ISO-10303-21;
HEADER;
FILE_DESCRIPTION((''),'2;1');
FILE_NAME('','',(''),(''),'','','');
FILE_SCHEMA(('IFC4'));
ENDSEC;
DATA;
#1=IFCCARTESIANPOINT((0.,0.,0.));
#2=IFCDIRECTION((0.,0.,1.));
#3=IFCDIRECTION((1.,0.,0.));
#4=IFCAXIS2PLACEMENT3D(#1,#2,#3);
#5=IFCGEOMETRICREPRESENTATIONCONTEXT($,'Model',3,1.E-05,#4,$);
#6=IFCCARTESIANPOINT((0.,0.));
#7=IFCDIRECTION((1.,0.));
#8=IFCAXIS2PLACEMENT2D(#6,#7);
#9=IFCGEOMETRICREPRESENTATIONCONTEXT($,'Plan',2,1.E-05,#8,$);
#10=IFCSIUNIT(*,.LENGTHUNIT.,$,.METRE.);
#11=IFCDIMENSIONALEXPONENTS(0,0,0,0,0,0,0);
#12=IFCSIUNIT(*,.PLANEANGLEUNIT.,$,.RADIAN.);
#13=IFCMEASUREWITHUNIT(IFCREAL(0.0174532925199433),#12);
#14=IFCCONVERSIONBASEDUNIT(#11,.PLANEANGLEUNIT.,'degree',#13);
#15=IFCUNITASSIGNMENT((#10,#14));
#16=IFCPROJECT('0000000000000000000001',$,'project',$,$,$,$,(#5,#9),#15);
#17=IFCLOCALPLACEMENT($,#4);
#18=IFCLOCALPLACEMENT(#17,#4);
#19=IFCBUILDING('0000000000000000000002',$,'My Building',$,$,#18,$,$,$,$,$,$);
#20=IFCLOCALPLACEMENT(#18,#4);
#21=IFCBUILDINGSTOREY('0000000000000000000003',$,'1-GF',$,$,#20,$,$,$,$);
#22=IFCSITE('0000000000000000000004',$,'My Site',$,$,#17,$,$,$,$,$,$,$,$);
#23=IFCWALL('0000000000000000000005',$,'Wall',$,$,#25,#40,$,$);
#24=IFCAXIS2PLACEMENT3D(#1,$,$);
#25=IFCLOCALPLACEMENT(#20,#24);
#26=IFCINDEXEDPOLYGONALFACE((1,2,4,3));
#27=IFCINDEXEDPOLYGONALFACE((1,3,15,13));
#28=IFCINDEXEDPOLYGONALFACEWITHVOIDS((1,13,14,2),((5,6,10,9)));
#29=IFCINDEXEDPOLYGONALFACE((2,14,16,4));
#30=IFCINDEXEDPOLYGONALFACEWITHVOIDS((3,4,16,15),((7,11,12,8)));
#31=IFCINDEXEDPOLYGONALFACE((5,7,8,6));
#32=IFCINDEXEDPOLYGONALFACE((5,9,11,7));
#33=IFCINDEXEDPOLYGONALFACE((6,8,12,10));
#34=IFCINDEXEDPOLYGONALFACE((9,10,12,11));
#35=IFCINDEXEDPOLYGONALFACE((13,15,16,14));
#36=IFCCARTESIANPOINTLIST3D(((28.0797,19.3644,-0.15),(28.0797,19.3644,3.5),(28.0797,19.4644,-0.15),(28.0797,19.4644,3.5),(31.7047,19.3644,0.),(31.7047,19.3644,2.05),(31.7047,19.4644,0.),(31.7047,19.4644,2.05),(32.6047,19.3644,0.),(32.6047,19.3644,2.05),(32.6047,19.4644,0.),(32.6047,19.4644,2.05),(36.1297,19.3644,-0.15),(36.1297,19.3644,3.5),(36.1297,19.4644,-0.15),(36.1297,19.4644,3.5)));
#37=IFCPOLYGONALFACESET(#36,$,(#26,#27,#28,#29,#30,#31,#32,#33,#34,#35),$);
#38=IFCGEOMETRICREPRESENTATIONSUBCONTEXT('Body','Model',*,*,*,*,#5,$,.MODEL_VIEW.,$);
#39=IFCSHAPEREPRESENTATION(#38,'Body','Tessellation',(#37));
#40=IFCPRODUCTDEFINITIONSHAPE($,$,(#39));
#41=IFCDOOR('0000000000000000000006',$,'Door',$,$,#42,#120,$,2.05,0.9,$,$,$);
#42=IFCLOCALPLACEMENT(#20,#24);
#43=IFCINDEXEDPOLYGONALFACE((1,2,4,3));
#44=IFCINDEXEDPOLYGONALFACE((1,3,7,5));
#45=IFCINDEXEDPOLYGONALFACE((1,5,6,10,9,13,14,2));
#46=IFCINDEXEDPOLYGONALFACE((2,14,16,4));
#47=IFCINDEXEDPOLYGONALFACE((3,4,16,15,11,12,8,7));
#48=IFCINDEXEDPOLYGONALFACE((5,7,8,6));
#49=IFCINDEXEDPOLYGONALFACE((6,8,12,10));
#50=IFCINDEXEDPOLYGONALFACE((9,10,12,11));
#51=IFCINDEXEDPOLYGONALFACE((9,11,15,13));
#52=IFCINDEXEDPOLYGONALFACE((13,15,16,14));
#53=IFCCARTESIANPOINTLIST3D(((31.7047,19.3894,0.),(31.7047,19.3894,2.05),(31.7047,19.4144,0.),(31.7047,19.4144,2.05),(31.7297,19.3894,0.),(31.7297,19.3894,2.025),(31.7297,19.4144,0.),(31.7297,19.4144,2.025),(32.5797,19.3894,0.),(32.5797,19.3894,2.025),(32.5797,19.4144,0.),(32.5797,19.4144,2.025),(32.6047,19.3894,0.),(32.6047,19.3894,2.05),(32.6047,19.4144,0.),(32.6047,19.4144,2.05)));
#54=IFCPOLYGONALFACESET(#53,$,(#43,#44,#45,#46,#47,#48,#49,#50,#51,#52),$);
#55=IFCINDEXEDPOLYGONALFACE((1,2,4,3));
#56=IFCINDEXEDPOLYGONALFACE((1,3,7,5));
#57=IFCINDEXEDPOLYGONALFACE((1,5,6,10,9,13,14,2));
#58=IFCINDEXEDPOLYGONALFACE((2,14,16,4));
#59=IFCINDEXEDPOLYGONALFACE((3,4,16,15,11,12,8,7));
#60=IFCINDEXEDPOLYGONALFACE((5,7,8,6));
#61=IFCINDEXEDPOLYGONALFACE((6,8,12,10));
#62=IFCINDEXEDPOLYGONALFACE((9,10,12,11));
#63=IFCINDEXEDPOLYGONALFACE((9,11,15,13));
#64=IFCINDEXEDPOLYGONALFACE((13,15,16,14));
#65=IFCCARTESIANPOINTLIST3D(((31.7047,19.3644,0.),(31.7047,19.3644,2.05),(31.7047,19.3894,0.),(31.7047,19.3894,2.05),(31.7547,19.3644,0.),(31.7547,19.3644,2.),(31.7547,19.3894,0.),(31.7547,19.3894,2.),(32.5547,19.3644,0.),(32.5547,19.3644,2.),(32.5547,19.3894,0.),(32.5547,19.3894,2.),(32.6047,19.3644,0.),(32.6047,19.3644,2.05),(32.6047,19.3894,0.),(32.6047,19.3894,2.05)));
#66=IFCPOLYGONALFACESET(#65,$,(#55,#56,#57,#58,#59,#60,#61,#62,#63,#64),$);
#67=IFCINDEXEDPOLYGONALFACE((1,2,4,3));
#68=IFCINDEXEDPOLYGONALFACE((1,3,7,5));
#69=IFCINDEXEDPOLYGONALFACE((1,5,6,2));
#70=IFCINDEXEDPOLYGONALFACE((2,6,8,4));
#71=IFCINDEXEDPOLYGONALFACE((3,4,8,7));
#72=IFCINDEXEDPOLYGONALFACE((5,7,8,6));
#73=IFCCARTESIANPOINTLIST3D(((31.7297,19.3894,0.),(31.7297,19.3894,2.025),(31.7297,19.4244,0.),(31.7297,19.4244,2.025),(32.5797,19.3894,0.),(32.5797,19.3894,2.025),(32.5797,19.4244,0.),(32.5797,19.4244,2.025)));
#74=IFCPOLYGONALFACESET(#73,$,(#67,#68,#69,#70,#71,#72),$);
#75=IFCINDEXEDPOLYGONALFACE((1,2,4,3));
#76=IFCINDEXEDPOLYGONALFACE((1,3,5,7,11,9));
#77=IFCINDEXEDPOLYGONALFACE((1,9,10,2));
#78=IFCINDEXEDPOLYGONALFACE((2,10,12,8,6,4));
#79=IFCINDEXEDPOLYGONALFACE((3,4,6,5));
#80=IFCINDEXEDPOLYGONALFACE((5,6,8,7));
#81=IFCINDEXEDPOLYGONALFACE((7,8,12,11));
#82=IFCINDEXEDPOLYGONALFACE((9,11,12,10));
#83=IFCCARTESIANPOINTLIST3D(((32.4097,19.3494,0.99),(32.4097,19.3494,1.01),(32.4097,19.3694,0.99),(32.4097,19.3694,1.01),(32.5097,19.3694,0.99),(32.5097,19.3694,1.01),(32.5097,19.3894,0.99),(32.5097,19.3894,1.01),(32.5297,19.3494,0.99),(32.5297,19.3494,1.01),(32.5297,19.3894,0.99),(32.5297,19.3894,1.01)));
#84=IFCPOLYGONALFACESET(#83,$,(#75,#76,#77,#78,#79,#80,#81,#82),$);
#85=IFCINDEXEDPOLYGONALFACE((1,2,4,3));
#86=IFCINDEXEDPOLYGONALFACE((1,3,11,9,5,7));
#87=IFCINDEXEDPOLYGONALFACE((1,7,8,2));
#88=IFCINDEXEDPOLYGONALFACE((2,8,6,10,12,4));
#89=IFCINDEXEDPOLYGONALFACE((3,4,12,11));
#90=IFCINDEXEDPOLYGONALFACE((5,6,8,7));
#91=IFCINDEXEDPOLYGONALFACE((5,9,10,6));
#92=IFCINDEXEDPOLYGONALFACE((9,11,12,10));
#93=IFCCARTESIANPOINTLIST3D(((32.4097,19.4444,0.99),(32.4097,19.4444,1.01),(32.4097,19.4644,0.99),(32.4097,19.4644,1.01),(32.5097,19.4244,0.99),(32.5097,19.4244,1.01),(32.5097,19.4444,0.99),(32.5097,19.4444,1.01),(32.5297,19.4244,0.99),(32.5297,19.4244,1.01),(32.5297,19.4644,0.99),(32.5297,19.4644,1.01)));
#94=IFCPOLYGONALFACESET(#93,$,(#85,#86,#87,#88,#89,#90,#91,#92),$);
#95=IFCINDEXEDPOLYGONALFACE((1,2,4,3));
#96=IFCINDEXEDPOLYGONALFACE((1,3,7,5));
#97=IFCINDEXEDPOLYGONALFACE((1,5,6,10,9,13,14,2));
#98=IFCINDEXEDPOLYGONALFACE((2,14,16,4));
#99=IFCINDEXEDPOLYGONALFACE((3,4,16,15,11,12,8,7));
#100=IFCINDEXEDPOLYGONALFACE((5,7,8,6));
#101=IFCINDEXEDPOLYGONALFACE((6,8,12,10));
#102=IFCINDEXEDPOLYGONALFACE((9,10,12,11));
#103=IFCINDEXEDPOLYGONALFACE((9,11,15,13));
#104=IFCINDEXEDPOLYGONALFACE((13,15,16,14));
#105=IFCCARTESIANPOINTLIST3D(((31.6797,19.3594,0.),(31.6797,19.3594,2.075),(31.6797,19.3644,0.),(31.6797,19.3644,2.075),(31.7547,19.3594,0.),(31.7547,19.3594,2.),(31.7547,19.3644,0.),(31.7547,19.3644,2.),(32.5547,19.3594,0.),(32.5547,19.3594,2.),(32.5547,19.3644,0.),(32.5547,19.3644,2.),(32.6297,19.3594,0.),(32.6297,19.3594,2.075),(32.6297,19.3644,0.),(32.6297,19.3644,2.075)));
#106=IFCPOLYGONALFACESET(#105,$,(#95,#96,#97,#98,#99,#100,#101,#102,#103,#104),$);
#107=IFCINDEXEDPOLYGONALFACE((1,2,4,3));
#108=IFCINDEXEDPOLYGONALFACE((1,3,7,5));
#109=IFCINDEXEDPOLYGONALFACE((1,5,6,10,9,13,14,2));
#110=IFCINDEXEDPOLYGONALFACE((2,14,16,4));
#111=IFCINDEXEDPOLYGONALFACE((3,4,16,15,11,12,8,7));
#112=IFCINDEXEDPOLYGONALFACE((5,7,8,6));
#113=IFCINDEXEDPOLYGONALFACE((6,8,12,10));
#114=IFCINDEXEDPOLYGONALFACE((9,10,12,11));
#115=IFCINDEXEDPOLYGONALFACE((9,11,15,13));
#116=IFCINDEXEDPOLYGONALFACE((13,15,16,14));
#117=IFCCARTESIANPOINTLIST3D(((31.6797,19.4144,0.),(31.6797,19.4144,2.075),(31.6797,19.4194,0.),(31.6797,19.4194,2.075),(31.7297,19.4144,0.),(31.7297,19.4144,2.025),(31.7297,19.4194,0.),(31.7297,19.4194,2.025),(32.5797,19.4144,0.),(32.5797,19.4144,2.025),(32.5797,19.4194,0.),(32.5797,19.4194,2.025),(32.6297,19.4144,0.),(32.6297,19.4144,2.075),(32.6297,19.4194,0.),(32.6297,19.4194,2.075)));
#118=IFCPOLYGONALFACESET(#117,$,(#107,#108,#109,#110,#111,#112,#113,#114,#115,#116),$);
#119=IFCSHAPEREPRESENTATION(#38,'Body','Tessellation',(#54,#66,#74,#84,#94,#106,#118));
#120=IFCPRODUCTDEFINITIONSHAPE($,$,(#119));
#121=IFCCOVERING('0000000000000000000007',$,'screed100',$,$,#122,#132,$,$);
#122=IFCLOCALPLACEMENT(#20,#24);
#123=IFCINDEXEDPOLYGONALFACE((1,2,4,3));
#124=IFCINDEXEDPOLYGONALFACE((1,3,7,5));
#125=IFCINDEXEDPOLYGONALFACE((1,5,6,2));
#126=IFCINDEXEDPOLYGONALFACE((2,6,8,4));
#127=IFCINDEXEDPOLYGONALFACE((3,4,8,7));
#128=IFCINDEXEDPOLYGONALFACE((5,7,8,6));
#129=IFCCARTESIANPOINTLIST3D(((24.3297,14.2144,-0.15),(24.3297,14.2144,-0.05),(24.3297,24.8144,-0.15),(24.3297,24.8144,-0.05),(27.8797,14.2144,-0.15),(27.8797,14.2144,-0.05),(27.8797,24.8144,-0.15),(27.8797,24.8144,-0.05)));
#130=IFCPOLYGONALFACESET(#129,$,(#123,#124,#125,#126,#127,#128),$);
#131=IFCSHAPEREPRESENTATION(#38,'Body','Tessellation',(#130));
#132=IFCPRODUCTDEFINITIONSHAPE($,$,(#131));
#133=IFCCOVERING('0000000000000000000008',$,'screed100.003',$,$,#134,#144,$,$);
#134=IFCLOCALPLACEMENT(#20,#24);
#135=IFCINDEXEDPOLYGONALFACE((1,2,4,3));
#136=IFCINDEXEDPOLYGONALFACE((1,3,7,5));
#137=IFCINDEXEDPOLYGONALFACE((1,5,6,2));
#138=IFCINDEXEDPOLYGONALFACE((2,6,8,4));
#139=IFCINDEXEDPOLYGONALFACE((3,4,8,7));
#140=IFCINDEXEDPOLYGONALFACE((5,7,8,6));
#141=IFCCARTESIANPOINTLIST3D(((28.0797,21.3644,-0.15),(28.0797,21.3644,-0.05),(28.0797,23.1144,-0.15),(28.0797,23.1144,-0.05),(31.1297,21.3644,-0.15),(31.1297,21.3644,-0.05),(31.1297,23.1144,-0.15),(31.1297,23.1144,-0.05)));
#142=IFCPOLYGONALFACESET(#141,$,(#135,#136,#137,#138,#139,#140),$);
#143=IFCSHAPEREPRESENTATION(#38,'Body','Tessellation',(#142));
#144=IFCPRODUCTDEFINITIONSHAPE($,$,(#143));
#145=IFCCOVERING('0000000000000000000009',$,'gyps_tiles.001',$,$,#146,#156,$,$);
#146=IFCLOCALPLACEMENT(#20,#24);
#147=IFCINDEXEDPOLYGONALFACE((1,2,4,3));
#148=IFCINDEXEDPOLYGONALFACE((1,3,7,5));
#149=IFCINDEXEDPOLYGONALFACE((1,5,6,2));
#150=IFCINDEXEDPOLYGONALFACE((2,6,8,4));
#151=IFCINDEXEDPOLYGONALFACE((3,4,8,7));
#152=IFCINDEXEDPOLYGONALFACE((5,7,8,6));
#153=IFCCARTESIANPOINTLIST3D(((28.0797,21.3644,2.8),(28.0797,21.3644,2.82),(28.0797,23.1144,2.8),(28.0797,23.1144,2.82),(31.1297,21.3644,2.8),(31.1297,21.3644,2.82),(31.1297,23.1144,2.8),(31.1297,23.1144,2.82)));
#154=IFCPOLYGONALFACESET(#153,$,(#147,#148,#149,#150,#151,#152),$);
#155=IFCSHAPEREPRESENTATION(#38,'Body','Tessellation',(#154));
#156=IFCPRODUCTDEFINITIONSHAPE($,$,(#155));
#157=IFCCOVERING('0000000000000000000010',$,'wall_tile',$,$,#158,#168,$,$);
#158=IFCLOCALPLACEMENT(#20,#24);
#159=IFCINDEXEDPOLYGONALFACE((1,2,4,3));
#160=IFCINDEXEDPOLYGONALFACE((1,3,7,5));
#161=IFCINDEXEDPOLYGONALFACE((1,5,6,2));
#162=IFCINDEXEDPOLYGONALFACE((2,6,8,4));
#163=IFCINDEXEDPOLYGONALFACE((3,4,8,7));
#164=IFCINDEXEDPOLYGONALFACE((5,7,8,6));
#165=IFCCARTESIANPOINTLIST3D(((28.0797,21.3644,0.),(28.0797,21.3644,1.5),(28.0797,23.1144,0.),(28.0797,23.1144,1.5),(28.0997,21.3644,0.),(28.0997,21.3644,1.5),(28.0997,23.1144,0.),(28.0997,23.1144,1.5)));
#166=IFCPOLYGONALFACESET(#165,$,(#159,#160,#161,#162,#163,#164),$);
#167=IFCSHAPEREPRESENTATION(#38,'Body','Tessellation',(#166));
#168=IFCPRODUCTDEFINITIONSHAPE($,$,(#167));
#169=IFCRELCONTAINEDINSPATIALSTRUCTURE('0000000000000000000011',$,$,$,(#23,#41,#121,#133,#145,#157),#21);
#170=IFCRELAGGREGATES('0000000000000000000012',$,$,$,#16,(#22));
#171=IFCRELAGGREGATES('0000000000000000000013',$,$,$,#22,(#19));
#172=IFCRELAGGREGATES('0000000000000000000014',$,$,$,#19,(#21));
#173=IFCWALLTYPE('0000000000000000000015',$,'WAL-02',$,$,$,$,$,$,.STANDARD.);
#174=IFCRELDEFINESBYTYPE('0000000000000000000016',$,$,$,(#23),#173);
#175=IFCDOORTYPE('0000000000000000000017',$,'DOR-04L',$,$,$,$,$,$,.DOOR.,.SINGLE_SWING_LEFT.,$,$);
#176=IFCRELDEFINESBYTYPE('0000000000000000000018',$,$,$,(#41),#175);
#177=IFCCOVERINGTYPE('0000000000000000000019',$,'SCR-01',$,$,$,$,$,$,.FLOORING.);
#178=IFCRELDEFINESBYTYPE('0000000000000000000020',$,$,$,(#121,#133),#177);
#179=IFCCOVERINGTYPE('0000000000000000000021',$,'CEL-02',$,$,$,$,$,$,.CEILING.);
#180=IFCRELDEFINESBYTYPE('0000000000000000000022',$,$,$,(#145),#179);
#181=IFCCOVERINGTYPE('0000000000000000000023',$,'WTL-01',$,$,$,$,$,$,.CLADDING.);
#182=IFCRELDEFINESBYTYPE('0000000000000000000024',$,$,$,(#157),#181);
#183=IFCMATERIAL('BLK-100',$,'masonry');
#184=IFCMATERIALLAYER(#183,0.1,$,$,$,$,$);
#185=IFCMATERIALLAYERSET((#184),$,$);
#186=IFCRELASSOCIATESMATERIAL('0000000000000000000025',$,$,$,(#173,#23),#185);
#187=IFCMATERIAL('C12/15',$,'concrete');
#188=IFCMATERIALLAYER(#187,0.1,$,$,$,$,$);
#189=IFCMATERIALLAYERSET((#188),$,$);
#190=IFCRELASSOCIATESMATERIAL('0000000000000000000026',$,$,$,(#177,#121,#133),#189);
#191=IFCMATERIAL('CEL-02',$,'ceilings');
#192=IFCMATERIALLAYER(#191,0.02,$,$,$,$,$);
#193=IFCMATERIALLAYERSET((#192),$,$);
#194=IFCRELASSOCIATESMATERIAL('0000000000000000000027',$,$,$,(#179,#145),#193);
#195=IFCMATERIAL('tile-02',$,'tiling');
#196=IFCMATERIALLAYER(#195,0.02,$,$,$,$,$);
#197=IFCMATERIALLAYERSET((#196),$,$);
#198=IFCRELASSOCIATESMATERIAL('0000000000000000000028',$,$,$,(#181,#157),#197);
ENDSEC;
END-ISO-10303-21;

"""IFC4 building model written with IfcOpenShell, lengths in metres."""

from ifc_helpers import new_model, entity, si_unit, converted_unit, frame, origin_with_axes, origin_2d_with_axis, place, context, subcontext, project, spatial, line, indexed_curve, outline, extrude, shape, source, transform, mapped, material, layer, layer_set, layer_usage, type_object, type_shapes, element, fill, save


model = new_model("IFC4")

# Units and contexts
model_context = context("Model", 3, precision=1e-05, world=origin_with_axes())
plan_context = context("Plan", 2, precision=1e-05, world=origin_2d_with_axis())
body_context_1 = subcontext(model_context, "Body", "Model", "MODEL_VIEW")
body_context_2 = subcontext(plan_context, "Body", "Plan", "PLAN_VIEW")
ifc_project = project(units=[si_unit("LENGTHUNIT", "METRE"), converted_unit("PLANEANGLEUNIT", "degree", entity("IfcReal", 0.0174532925199433), si_unit("PLANEANGLEUNIT", "RADIAN"), dimensions=[0, 0, 0, 0, 0, 0, 0])], contexts=[model_context, plan_context])

# Site, building, storey
site_placement = place(None, origin_with_axes())
site = spatial("IfcSite", under=ifc_project, at=site_placement, Name="My Site")
building_placement = place(site_placement, origin_with_axes())
building = spatial("IfcBuilding", under=site, at=building_placement, Name="My Building")
storey_placement = place(building_placement, origin_with_axes())
storey = spatial("IfcBuildingStorey", under=building, at=storey_placement, Name="1-GF")

# Wall, opening, door
ifc_material_1 = material(Name="BLK-100", Category="masonry")
ifc_layer_1 = layer(ifc_material_1, 0.1)
ifc_layer_set_1 = layer_set([ifc_layer_1])
ifc_layer_usage_1 = layer_usage(ifc_layer_set_1, "AXIS2", "POSITIVE", 0.0)
wall_type_1 = type_object("IfcWallType", Name="WAL-02", PredefinedType="STANDARD", material=ifc_layer_set_1)
wall_1_placement = place(storey_placement, frame((28.0797, 19.3644, -0.15), z_axis=(0.0, 0.0, 1.0), x_axis=(1.0, -0.000001, 0.0)))
wall_1 = element("IfcWall", 1, at=wall_1_placement, inside=storey, type_object=wall_type_1, material=ifc_layer_usage_1, Name="Wall", context=body_context_1, shape_type="SweptSolid", body=[
    extrude(outline(indexed_curve([(0.0, 0.0), (0.0, 0.1), (8.05, 0.1), (8.05, 0.0), (0.0, 0.0)], self_intersect=False)), origin_with_axes(), (0.0, 0.0, 1.0), 3.65),
])
shared_shape_1 = source(origin_with_axes(), body_context_1, "Body", "SweptSolid", [
    extrude(outline(indexed_curve([(0.0, 0.0), (0.9, 0.0), (0.9, 2.05), (0.0, 2.05)], segments=[line(1, 2, 3, 4, 1)])), frame((0.0, -0.6, 0.0), z_axis=(0.0, -1.0, 0.0), x_axis=(1.0, 0.0, 0.0)), (0.0, 0.0, -1.0), 1.2),
])
opening_1_placement = place(wall_1_placement, frame((3.625, 0.0, 0.15), z_axis=(0.0, 0.0, 1.0), x_axis=(1.0, 0.0, 0.0)))
opening_1 = element("IfcOpeningElement", 2, at=opening_1_placement, cuts=wall_1, PredefinedType="OPENING", context=body_context_1, shape_type="MappedRepresentation", body=[
    mapped(shared_shape_1, transform((0.0, 0.0, 0.0), x_axis=(1.0, 0.0, 0.0), y_axis=(0.0, 1.0, 0.0), z_axis=(0.0, 0.0, 1.0), scale=1.0)),
])
door_type_1 = type_object("IfcDoorType", Name="DOR-04L", OperationType="SINGLE_SWING_LEFT", PredefinedType="DOOR")
shared_shape_2 = source(origin_with_axes(), body_context_1, "Body", "SweptSolid", [
    extrude(outline(indexed_curve([(0.0, 0.0), (0.0, 2.05), (0.9, 2.05), (0.9, 0.0), (0.875, 0.0), (0.875, 2.025), (0.025, 2.025), (0.025, 0.0)], segments=[line(1, 2, 3, 4, 5, 6, 7, 8, 1)])), frame((0.0, 0.025, 0.0), z_axis=(0.0, -1.0, 0.0), x_axis=(1.0, 0.0, 0.0)), (0.0, 0.0, -1.0), 0.025),
    extrude(outline(indexed_curve([(0.0, 0.0), (0.0, 2.05), (0.9, 2.05), (0.9, 0.0), (0.85, 0.0), (0.85, 2.0), (0.05, 2.0), (0.05, 0.0)], segments=[line(1, 2, 3, 4, 5, 6, 7, 8, 1)])), frame((0.0, 0.0, 0.0), z_axis=(0.0, -1.0, 0.0), x_axis=(1.0, 0.0, 0.0)), (0.0, 0.0, -1.0), 0.025),
    extrude(outline(indexed_curve([(0.0, 0.0), (0.85, 0.0), (0.85, 0.035), (0.0, 0.035)], segments=[line(1, 2, 3, 4, 1)])), frame((0.025, 0.025, 0.0), z_axis=(0.0, 0.0, 1.0), x_axis=(1.0, 0.0, 0.0)), (0.0, 0.0, 1.0), 2.025),
    extrude(outline(indexed_curve([(0.0, 0.0), (0.0, -0.04), (-0.12, -0.04), (-0.12, -0.02), (-0.02, -0.02), (-0.02, 0.0)], segments=[line(1, 2, 3, 4, 5, 6, 1)])), frame((0.825, 0.025, 0.99), z_axis=(0.0, 0.0, 1.0), x_axis=(1.0, 0.0, 0.0)), (0.0, 0.0, 1.0), 0.02),
    extrude(outline(indexed_curve([(0.0, 0.0), (0.0, 0.04), (-0.12, 0.04), (-0.12, 0.02), (-0.02, 0.02), (-0.02, 0.0)], segments=[line(1, 2, 3, 4, 5, 6, 1)])), frame((0.825, 0.06, 0.99), z_axis=(0.0, 0.0, 1.0), x_axis=(1.0, 0.0, 0.0)), (0.0, 0.0, 1.0), 0.02),
    extrude(outline(indexed_curve([(0.0, 0.0), (0.0, 2.075), (0.95, 2.075), (0.95, 0.0), (0.875, 0.0), (0.875, 2.0), (0.075, 2.0), (0.075, 0.0)], segments=[line(1, 2, 3, 4, 5, 6, 7, 8, 1)])), frame((-0.025, -0.005, 0.0), z_axis=(0.0, -1.0, 0.0), x_axis=(1.0, 0.0, 0.0)), (0.0, 0.0, -1.0), 0.005),
    extrude(outline(indexed_curve([(0.0, 0.0), (0.0, 2.075), (0.95, 2.075), (0.95, 0.0), (0.9, 0.0), (0.9, 2.025), (0.05, 2.025), (0.05, 0.0)], segments=[line(1, 2, 3, 4, 5, 6, 7, 8, 1)])), frame((-0.025, 0.05, 0.0), z_axis=(0.0, -1.0, 0.0), x_axis=(1.0, 0.0, 0.0)), (0.0, 0.0, -1.0), 0.005),
])
shared_shape_3 = source(origin_with_axes(), body_context_2, "Body", "Curve2D", [
    entity("IfcIndexedPolyCurve", entity("IfcCartesianPointList2D", [[0.0, 0.0], [0.0, 0.05], [0.025, 0.05], [0.025, 0.025], [0.05, 0.025], [0.05, 0.0]]), [entity("IfcLineIndex", [1, 2, 3, 4, 5, 6, 1])]),
    entity("IfcIndexedPolyCurve", entity("IfcCartesianPointList2D", [[0.9, 0.0], [0.9, 0.05], [0.875, 0.05], [0.875, 0.025], [0.85, 0.025], [0.85, 0.0]]), [entity("IfcLineIndex", [1, 2, 3, 4, 5, 6, 1])]),
    entity("IfcTrimmedCurve", entity("IfcEllipse", entity("IfcAxis2Placement2D", entity("IfcCartesianPoint", [0.06, 0.05]), entity("IfcDirection", [1.0, 0.0])), 0.815, 0.85), [entity("IfcCartesianPoint", [0.875, 0.05])], [entity("IfcCartesianPoint", [0.06, 0.9])], True, "CARTESIAN"),
    entity("IfcIndexedPolyCurve", entity("IfcCartesianPointList2D", [[0.025, 0.05], [0.06, 0.05], [0.06, 0.9], [0.025, 0.9]]), [entity("IfcLineIndex", [1, 2, 3, 4, 1])]),
])
type_shapes(door_type_1, [shared_shape_2, shared_shape_3])
door_1_placement = place(opening_1_placement, frame((0.0, 0.0, 0.0), z_axis=(0.0, 0.0, 1.0), x_axis=(1.0, 0.0, 0.0)))
door_1 = element("IfcDoor", 3, at=door_1_placement, inside=storey, type_object=door_type_1, Name="Door", OverallHeight=2.05, OverallWidth=0.9, shapes=[
    shape(body_context_1, "Body", "MappedRepresentation", [mapped(shared_shape_2, transform((0.0, 0.0, 0.0), x_axis=(1.0, 0.0, 0.0), y_axis=(0.0, 1.0, 0.0), z_axis=(0.0, 0.0, 1.0), scale=1.0))]),
    shape(body_context_2, "Body", "MappedRepresentation", [mapped(shared_shape_3, transform((0.0, 0.0, 0.0), x_axis=(1.0, 0.0, 0.0), y_axis=(0.0, 1.0, 0.0), z_axis=(0.0, 0.0, 1.0), scale=1.0))]),
])
fill(opening_1, door_1)

# Coverings
ifc_material_2 = material(Name="C12/15", Category="concrete")
ifc_layer_2 = layer(ifc_material_2, 0.1)
ifc_layer_set_2 = layer_set([ifc_layer_2])
ifc_layer_usage_2 = layer_usage(ifc_layer_set_2, "AXIS3", "POSITIVE", 0.0)
covering_type_1 = type_object("IfcCoveringType", Name="SCR-01", PredefinedType="FLOORING", material=ifc_layer_set_2)
covering_1_placement = place(storey_placement, frame((24.3297, 14.2144, -0.15), z_axis=(0.0, 0.0, 1.0), x_axis=(1.0, 0.0, 0.0)))
element("IfcCovering", 4, at=covering_1_placement, inside=storey, type_object=covering_type_1, material=ifc_layer_usage_2, Name="screed100", context=body_context_1, shape_type="SweptSolid", body=[
    extrude(outline(indexed_curve([(0.0, 10.6), (0.0, 0.0), (3.55, 0.0), (3.55, 10.6)], segments=[line(4, 1), line(1, 2), line(2, 3), line(3, 4)], self_intersect=False)), None, (0.0, 0.0, 1.0), 0.1),
])
ifc_layer_usage_3 = layer_usage(ifc_layer_set_2, "AXIS3", "POSITIVE", 0.0)
covering_2_placement = place(storey_placement, frame((28.0797, 21.3644, -0.15), z_axis=(0.0, 0.0, 1.0), x_axis=(1.0, 0.0, 0.0)))
element("IfcCovering", 5, at=covering_2_placement, inside=storey, type_object=covering_type_1, material=ifc_layer_usage_3, Name="screed100.003", context=body_context_1, shape_type="SweptSolid", body=[
    extrude(outline(indexed_curve([(0.0, 0.0), (3.05, 0.0), (3.05, 1.75), (0.0, 1.75)], segments=[line(4, 1), line(1, 2), line(2, 3), line(3, 4)], self_intersect=False)), None, (0.0, 0.0, 1.0), 0.1),
])
ifc_material_3 = material(Name="CEL-02", Category="ceilings")
ifc_layer_3 = layer(ifc_material_3, 0.02)
ifc_layer_set_3 = layer_set([ifc_layer_3])
ifc_layer_usage_4 = layer_usage(ifc_layer_set_3, "AXIS3", "POSITIVE", 0.0)
covering_type_2 = type_object("IfcCoveringType", Name="CEL-02", PredefinedType="CEILING", material=ifc_layer_set_3)
covering_3_placement = place(storey_placement, frame((28.0797, 21.3644, 2.8), z_axis=(0.0, 0.0, 1.0), x_axis=(1.0, 0.0, 0.0)))
element("IfcCovering", 6, at=covering_3_placement, inside=storey, type_object=covering_type_2, material=ifc_layer_usage_4, Name="gyps_tiles.001", context=body_context_1, shape_type="SweptSolid", body=[
    extrude(outline(indexed_curve([(0.0, 1.75), (0.0, 0.0), (3.05, 0.0), (3.05, 1.75)], segments=[line(3, 2), line(2, 1), line(1, 4), line(4, 3)], self_intersect=False)), None, (0.0, 0.0, 1.0), 0.02),
])
ifc_material_4 = material(Name="tile-02", Category="tiling")
ifc_layer_4 = layer(ifc_material_4, 0.02)
ifc_layer_set_4 = layer_set([ifc_layer_4])
ifc_layer_usage_5 = layer_usage(ifc_layer_set_4, "AXIS2", "POSITIVE", 0.0)
covering_type_3 = type_object("IfcCoveringType", Name="WTL-01", PredefinedType="CLADDING", material=ifc_layer_set_4)
covering_4_placement = place(storey_placement, frame((28.0997, 21.3644, 0.0), z_axis=(0.0, 0.0, 1.0), x_axis=(0.000001, 1.0, 0.0)))
element("IfcCovering", 7, at=covering_4_placement, inside=storey, type_object=covering_type_3, material=ifc_layer_usage_5, Name="wall_tile", context=body_context_1, shape_type="SweptSolid", body=[
    extrude(outline(indexed_curve([(0.0, 0.0), (0.0, 0.02), (1.75, 0.02), (1.75, 0.0), (0.0, 0.0)], self_intersect=False)), origin_with_axes(), (0.0, 0.0, 1.0), 1.5),
])

save(model, "model.ifc")
